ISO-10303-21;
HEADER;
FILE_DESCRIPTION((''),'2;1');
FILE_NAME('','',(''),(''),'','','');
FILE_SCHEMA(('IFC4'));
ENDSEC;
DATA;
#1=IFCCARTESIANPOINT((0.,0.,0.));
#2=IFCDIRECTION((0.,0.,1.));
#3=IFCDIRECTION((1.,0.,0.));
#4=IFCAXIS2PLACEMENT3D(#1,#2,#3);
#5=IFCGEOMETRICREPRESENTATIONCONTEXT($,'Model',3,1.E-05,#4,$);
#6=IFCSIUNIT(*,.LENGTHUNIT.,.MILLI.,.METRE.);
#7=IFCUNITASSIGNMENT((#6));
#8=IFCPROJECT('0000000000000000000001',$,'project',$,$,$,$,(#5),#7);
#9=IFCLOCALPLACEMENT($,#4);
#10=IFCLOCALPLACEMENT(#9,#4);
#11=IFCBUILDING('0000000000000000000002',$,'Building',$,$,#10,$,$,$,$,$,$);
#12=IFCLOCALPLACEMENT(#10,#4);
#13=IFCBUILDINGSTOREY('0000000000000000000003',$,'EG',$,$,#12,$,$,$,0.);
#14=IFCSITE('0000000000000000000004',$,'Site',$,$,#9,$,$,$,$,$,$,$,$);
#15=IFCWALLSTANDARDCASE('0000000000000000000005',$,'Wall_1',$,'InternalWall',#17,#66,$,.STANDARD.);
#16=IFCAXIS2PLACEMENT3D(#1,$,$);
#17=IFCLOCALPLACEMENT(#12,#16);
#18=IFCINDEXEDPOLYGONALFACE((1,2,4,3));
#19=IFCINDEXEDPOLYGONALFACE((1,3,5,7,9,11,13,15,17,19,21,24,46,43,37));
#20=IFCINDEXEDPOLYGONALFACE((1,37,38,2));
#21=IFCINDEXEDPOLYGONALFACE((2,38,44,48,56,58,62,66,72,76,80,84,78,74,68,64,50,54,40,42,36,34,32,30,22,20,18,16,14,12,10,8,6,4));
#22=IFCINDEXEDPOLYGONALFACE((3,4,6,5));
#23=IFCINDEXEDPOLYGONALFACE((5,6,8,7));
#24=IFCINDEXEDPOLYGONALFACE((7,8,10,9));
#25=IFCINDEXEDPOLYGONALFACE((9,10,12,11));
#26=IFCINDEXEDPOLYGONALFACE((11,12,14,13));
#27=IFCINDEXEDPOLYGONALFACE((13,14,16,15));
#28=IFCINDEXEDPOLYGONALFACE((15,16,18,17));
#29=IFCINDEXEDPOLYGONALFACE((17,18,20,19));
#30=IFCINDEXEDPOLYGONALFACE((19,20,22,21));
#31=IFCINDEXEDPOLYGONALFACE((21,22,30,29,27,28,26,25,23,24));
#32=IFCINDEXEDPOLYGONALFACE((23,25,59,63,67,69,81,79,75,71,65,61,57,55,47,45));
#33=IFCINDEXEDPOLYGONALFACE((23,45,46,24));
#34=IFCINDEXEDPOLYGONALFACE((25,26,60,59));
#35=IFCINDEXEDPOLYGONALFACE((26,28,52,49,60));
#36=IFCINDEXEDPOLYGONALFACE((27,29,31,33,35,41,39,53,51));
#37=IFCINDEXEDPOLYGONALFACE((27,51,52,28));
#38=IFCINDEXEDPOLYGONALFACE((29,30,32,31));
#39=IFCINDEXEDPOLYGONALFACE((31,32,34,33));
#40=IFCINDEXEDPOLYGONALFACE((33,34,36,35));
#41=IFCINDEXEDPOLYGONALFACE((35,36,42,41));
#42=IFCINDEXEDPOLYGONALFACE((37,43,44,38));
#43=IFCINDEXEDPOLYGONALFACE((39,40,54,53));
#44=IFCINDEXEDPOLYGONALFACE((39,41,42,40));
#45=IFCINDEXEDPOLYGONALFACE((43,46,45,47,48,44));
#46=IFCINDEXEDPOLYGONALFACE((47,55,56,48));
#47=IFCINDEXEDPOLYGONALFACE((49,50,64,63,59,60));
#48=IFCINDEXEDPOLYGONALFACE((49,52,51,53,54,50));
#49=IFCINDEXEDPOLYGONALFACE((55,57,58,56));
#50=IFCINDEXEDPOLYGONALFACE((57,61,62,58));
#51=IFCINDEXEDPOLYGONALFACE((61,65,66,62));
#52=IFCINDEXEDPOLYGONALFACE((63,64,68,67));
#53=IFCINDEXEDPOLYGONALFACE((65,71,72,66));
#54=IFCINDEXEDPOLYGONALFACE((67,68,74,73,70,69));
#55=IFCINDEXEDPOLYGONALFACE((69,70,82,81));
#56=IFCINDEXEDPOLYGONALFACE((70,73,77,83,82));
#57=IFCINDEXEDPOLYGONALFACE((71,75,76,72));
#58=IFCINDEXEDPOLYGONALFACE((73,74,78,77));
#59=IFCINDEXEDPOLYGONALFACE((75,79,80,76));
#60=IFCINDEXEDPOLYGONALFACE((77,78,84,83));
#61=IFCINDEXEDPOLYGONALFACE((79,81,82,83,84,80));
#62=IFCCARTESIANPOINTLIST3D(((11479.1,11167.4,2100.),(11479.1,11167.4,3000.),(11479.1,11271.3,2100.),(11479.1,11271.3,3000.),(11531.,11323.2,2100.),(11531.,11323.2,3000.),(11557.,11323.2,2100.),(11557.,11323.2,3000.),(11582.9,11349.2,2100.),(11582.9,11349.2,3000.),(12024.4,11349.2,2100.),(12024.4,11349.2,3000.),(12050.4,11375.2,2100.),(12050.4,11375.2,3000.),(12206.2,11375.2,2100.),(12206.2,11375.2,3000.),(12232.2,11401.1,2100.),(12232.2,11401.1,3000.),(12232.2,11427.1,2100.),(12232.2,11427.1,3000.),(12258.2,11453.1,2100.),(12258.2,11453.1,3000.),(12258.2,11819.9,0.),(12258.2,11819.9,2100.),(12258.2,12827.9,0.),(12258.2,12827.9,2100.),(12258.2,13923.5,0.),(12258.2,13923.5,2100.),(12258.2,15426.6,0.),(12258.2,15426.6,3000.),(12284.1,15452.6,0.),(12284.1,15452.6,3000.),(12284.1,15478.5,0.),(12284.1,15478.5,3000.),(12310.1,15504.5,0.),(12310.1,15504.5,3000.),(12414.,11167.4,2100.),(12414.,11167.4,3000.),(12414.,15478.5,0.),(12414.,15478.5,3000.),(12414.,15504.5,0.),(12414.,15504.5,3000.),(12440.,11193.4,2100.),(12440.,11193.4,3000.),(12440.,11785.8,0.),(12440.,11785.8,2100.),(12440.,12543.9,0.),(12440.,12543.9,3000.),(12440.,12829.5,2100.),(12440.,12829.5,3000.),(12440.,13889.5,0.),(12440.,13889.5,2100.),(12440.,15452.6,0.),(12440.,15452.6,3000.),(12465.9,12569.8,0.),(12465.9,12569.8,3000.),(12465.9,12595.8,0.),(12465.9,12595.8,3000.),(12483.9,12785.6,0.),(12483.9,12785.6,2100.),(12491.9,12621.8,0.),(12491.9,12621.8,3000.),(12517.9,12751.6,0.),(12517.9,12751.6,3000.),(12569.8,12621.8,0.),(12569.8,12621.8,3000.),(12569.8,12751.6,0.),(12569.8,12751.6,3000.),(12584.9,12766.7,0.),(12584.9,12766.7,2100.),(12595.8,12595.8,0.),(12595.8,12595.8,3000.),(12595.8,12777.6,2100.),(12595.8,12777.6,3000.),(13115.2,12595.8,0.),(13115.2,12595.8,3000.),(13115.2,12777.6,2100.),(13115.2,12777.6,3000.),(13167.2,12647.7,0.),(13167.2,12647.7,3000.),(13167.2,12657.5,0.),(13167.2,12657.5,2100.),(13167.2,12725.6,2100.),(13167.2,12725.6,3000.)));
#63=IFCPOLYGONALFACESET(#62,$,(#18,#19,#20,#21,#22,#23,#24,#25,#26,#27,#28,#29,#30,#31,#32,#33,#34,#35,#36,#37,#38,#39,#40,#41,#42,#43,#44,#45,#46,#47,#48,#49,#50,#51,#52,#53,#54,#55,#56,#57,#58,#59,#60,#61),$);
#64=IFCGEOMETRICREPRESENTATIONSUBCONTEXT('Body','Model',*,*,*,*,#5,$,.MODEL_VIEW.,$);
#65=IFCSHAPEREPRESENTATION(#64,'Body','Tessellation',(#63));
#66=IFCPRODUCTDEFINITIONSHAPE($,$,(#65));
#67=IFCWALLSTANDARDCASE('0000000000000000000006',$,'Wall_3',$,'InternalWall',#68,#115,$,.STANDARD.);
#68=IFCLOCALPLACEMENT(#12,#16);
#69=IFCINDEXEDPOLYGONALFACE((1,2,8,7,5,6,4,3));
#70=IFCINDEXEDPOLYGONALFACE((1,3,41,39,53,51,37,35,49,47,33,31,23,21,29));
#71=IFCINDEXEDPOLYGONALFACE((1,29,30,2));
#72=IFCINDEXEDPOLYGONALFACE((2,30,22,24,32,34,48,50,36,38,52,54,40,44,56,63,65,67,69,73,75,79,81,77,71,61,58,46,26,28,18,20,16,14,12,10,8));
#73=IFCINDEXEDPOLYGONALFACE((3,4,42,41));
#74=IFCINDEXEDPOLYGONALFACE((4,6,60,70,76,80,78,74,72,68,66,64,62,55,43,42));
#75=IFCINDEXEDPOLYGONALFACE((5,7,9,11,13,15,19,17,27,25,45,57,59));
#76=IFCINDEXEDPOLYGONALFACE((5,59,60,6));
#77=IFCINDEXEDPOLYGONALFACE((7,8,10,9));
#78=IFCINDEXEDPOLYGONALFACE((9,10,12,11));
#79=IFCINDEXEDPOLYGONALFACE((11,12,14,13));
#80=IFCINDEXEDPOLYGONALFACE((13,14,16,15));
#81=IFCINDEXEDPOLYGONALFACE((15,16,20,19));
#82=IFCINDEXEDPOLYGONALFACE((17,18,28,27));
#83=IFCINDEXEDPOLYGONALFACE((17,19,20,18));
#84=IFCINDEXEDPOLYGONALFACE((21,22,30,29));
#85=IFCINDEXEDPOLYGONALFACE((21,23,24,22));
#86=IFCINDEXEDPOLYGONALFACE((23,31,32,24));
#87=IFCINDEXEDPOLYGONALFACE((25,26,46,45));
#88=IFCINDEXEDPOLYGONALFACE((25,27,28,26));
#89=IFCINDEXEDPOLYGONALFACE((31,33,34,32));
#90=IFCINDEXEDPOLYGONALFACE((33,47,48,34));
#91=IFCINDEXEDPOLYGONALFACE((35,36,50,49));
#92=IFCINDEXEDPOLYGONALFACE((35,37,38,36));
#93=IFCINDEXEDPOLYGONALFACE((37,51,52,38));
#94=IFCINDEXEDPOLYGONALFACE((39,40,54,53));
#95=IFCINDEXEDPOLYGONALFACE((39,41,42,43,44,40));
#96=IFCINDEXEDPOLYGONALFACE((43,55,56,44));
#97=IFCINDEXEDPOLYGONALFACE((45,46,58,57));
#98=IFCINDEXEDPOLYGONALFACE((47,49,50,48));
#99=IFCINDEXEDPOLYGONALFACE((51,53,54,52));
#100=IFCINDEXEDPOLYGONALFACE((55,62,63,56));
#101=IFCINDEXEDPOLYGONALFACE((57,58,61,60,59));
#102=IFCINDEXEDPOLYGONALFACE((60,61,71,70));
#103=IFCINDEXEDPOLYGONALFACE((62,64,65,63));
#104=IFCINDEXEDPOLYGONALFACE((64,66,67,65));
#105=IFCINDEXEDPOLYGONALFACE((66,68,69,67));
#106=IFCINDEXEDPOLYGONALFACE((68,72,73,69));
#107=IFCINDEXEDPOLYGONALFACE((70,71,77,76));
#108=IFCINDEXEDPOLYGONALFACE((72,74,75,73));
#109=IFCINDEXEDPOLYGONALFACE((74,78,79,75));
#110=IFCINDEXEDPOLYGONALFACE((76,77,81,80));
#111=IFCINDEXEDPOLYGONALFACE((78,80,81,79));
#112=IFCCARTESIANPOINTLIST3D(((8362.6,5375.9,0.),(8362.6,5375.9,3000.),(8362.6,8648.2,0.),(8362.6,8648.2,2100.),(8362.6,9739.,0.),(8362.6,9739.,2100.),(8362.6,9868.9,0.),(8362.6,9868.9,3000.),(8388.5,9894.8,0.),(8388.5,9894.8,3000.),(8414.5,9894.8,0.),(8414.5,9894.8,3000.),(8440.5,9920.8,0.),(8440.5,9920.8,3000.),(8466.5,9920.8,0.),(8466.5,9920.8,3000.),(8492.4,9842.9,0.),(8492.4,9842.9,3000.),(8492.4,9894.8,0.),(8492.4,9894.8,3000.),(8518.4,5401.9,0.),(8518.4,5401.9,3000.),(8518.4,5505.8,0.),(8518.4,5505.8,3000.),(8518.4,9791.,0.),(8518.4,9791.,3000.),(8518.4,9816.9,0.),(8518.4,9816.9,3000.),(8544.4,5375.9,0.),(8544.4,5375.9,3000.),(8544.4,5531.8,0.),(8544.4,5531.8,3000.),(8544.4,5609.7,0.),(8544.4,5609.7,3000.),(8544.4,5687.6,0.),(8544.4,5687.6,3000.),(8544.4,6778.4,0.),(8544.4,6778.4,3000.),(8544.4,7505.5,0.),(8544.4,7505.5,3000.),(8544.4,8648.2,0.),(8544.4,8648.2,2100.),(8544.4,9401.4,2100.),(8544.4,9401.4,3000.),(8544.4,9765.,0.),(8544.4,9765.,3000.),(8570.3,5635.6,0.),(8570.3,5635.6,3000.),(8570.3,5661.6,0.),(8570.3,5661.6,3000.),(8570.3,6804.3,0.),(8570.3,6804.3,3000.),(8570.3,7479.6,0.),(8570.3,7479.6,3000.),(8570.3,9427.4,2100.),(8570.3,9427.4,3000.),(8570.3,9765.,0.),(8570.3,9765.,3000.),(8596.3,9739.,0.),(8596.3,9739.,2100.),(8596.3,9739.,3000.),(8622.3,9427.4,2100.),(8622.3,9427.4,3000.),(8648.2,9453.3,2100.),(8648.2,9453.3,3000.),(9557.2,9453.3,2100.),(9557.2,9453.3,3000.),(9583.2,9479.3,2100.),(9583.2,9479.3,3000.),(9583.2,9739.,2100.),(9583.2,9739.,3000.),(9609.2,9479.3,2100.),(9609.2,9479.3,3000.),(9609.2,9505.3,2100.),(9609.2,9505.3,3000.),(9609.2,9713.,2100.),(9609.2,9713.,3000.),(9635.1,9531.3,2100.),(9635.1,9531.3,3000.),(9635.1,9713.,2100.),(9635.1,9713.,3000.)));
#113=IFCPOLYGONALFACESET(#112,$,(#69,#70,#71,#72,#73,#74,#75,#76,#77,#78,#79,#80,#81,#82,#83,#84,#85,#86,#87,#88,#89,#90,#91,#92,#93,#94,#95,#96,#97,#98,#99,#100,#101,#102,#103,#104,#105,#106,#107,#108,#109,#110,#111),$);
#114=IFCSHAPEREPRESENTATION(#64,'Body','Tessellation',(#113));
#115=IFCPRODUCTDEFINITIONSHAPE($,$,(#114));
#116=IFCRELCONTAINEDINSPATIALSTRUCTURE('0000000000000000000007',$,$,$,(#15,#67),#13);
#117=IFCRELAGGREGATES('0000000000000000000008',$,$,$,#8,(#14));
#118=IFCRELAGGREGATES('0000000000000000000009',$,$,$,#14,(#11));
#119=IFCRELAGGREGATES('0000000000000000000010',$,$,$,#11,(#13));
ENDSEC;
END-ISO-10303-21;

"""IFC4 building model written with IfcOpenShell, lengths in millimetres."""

from ifc_helpers import new_model, si_unit, frame, origin_with_axes, place, context, subcontext, project, spatial, polyline, rectangle, outline, extrude, element, save


model = new_model("IFC4")

# Units and contexts
model_context = context("Model", 3, precision=1e-05, world=origin_with_axes())
body_context = subcontext(model_context, "Body", "Model", "MODEL_VIEW")
ifc_project = project(units=[si_unit("LENGTHUNIT", "METRE", prefix="MILLI")], contexts=[model_context])

# Site, building, storey
site_placement = place(None, origin_with_axes())
site = spatial("IfcSite", under=ifc_project, at=site_placement, Name="Site")
building_placement = place(site_placement, origin_with_axes())
building = spatial("IfcBuilding", under=site, at=building_placement, Name="Building")
storey_placement = place(building_placement, origin_with_axes())
storey = spatial("IfcBuildingStorey", under=building, at=storey_placement, Name="EG", Elevation=0.0)

# Walls, openings
wall_1_placement = place(storey_placement, origin_with_axes())
wall_1 = element("IfcWallStandardCase", 1, at=wall_1_placement, inside=storey, Name="Wall_1", ObjectType="InternalWall", PredefinedType="STANDARD", context=body_context, shape_type="SweptSolid", body=[
    extrude(outline(polyline([(11479.1, 11167.4, 0.0), (11479.1, 11271.3, 0.0), (11531.0, 11323.2, 0.0), (11557.0, 11323.2, 0.0), (11582.9, 11349.2, 0.0), (12024.4, 11349.2, 0.0), (12050.4, 11375.2, 0.0), (12206.2, 11375.2, 0.0), (12232.2, 11401.1, 0.0), (12232.2, 11427.1, 0.0), (12258.2, 11453.1, 0.0), (12258.2, 15426.6, 0.0), (12284.1, 15452.6, 0.0), (12284.1, 15478.5, 0.0), (12310.1, 15504.5, 0.0), (12414.0, 15504.5, 0.0), (12414.0, 15478.5, 0.0), (12440.0, 15452.6, 0.0), (12440.0, 12829.5, 0.0), (12517.9, 12751.6, 0.0), (12569.8, 12751.6, 0.0), (12595.8, 12777.6, 0.0), (13115.2, 12777.6, 0.0), (13167.2, 12725.6, 0.0), (13167.2, 12647.7, 0.0), (13115.2, 12595.8, 0.0), (12595.8, 12595.8, 0.0), (12569.8, 12621.8, 0.0), (12491.9, 12621.8, 0.0), (12465.9, 12595.8, 0.0), (12465.9, 12569.8, 0.0), (12440.0, 12543.9, 0.0), (12440.0, 11193.4, 0.0), (12414.0, 11167.4, 0.0), (11479.1, 11167.4, 0.0)])), origin_with_axes(), (0.0, 0.0, 1.0), 3000.0),
])
opening_1_placement = place(wall_1_placement, origin_with_axes())
element("IfcOpeningElement", 2, at=opening_1_placement, inside=storey, cuts=wall_1, context=body_context, shape_type="SweptSolid", body=[
    extrude(rectangle(XDim=1076.9, YDim=1405.5), frame((12577.4, 13315.9, 0.0), z_axis=(0.0, 0.0, 1.0), x_axis=(0.184288, 0.982872, 0.0)), (0.0, 0.0, 1.0), 2100.0),
])
opening_2_placement = place(wall_1_placement, origin_with_axes())
element("IfcOpeningElement", 3, at=opening_2_placement, inside=storey, cuts=wall_1, context=body_context, shape_type="SweptSolid", body=[
    extrude(rectangle(XDim=784.9, YDim=1405.5), frame((12223.3, 11427.2, 0.0), z_axis=(0.0, 0.0, 1.0), x_axis=(0.184288, 0.982872, 0.0)), (0.0, 0.0, 1.0), 2100.0),
])
wall_2_placement = place(storey_placement, origin_with_axes())
wall_2 = element("IfcWallStandardCase", 4, at=wall_2_placement, inside=storey, Name="Wall_3", ObjectType="InternalWall", PredefinedType="STANDARD", context=body_context, shape_type="SweptSolid", body=[
    extrude(outline(polyline([(8362.6, 5375.9, 0.0), (8362.6, 9868.9, 0.0), (8388.5, 9894.8, 0.0), (8414.5, 9894.8, 0.0), (8440.5, 9920.8, 0.0), (8466.5, 9920.8, 0.0), (8492.4, 9894.8, 0.0), (8492.4, 9842.9, 0.0), (8518.4, 9816.9, 0.0), (8518.4, 9791.0, 0.0), (8544.4, 9765.0, 0.0), (8570.3, 9765.0, 0.0), (8596.3, 9739.0, 0.0), (9583.2, 9739.0, 0.0), (9609.2, 9713.0, 0.0), (9635.1, 9713.0, 0.0), (9635.1, 9531.3, 0.0), (9609.2, 9505.3, 0.0), (9609.2, 9479.3, 0.0), (9583.2, 9479.3, 0.0), (9557.2, 9453.3, 0.0), (8648.2, 9453.3, 0.0), (8622.3, 9427.4, 0.0), (8570.3, 9427.4, 0.0), (8544.4, 9401.4, 0.0), (8544.4, 7505.5, 0.0), (8570.3, 7479.6, 0.0), (8570.3, 6804.3, 0.0), (8544.4, 6778.4, 0.0), (8544.4, 5687.6, 0.0), (8570.3, 5661.6, 0.0), (8570.3, 5635.6, 0.0), (8544.4, 5609.7, 0.0), (8544.4, 5531.8, 0.0), (8518.4, 5505.8, 0.0), (8518.4, 5401.9, 0.0), (8544.4, 5375.9, 0.0), (8362.6, 5375.9, 0.0)])), origin_with_axes(), (0.0, 0.0, 1.0), 3000.0),
])
opening_3_placement = place(wall_2_placement, origin_with_axes())
element("IfcOpeningElement", 5, at=opening_3_placement, inside=storey, cuts=wall_2, context=body_context, shape_type="SweptSolid", body=[
    extrude(rectangle(XDim=1090.8, YDim=1272.6), frame((8998.9, 9193.6, 0.0), z_axis=(0.0, 0.0, 1.0), x_axis=(0.0, 1.0, 0.0)), (0.0, 0.0, 1.0), 2100.0),
])
opening_4_placement = place(wall_2_placement, origin_with_axes())
element("IfcOpeningElement", 6, at=opening_4_placement, inside=storey, cuts=wall_2, context=body_context, shape_type="SweptSolid", body=[
    extrude(rectangle(XDim=900.0, YDim=1272.6), frame((8028.3, 10525.9, 0.0), z_axis=(0.0, 0.0, 1.0), x_axis=(0.0, 1.0, 0.0)), (0.0, 0.0, 1.0), 2100.0),
])

save(model, "model.ifc")
